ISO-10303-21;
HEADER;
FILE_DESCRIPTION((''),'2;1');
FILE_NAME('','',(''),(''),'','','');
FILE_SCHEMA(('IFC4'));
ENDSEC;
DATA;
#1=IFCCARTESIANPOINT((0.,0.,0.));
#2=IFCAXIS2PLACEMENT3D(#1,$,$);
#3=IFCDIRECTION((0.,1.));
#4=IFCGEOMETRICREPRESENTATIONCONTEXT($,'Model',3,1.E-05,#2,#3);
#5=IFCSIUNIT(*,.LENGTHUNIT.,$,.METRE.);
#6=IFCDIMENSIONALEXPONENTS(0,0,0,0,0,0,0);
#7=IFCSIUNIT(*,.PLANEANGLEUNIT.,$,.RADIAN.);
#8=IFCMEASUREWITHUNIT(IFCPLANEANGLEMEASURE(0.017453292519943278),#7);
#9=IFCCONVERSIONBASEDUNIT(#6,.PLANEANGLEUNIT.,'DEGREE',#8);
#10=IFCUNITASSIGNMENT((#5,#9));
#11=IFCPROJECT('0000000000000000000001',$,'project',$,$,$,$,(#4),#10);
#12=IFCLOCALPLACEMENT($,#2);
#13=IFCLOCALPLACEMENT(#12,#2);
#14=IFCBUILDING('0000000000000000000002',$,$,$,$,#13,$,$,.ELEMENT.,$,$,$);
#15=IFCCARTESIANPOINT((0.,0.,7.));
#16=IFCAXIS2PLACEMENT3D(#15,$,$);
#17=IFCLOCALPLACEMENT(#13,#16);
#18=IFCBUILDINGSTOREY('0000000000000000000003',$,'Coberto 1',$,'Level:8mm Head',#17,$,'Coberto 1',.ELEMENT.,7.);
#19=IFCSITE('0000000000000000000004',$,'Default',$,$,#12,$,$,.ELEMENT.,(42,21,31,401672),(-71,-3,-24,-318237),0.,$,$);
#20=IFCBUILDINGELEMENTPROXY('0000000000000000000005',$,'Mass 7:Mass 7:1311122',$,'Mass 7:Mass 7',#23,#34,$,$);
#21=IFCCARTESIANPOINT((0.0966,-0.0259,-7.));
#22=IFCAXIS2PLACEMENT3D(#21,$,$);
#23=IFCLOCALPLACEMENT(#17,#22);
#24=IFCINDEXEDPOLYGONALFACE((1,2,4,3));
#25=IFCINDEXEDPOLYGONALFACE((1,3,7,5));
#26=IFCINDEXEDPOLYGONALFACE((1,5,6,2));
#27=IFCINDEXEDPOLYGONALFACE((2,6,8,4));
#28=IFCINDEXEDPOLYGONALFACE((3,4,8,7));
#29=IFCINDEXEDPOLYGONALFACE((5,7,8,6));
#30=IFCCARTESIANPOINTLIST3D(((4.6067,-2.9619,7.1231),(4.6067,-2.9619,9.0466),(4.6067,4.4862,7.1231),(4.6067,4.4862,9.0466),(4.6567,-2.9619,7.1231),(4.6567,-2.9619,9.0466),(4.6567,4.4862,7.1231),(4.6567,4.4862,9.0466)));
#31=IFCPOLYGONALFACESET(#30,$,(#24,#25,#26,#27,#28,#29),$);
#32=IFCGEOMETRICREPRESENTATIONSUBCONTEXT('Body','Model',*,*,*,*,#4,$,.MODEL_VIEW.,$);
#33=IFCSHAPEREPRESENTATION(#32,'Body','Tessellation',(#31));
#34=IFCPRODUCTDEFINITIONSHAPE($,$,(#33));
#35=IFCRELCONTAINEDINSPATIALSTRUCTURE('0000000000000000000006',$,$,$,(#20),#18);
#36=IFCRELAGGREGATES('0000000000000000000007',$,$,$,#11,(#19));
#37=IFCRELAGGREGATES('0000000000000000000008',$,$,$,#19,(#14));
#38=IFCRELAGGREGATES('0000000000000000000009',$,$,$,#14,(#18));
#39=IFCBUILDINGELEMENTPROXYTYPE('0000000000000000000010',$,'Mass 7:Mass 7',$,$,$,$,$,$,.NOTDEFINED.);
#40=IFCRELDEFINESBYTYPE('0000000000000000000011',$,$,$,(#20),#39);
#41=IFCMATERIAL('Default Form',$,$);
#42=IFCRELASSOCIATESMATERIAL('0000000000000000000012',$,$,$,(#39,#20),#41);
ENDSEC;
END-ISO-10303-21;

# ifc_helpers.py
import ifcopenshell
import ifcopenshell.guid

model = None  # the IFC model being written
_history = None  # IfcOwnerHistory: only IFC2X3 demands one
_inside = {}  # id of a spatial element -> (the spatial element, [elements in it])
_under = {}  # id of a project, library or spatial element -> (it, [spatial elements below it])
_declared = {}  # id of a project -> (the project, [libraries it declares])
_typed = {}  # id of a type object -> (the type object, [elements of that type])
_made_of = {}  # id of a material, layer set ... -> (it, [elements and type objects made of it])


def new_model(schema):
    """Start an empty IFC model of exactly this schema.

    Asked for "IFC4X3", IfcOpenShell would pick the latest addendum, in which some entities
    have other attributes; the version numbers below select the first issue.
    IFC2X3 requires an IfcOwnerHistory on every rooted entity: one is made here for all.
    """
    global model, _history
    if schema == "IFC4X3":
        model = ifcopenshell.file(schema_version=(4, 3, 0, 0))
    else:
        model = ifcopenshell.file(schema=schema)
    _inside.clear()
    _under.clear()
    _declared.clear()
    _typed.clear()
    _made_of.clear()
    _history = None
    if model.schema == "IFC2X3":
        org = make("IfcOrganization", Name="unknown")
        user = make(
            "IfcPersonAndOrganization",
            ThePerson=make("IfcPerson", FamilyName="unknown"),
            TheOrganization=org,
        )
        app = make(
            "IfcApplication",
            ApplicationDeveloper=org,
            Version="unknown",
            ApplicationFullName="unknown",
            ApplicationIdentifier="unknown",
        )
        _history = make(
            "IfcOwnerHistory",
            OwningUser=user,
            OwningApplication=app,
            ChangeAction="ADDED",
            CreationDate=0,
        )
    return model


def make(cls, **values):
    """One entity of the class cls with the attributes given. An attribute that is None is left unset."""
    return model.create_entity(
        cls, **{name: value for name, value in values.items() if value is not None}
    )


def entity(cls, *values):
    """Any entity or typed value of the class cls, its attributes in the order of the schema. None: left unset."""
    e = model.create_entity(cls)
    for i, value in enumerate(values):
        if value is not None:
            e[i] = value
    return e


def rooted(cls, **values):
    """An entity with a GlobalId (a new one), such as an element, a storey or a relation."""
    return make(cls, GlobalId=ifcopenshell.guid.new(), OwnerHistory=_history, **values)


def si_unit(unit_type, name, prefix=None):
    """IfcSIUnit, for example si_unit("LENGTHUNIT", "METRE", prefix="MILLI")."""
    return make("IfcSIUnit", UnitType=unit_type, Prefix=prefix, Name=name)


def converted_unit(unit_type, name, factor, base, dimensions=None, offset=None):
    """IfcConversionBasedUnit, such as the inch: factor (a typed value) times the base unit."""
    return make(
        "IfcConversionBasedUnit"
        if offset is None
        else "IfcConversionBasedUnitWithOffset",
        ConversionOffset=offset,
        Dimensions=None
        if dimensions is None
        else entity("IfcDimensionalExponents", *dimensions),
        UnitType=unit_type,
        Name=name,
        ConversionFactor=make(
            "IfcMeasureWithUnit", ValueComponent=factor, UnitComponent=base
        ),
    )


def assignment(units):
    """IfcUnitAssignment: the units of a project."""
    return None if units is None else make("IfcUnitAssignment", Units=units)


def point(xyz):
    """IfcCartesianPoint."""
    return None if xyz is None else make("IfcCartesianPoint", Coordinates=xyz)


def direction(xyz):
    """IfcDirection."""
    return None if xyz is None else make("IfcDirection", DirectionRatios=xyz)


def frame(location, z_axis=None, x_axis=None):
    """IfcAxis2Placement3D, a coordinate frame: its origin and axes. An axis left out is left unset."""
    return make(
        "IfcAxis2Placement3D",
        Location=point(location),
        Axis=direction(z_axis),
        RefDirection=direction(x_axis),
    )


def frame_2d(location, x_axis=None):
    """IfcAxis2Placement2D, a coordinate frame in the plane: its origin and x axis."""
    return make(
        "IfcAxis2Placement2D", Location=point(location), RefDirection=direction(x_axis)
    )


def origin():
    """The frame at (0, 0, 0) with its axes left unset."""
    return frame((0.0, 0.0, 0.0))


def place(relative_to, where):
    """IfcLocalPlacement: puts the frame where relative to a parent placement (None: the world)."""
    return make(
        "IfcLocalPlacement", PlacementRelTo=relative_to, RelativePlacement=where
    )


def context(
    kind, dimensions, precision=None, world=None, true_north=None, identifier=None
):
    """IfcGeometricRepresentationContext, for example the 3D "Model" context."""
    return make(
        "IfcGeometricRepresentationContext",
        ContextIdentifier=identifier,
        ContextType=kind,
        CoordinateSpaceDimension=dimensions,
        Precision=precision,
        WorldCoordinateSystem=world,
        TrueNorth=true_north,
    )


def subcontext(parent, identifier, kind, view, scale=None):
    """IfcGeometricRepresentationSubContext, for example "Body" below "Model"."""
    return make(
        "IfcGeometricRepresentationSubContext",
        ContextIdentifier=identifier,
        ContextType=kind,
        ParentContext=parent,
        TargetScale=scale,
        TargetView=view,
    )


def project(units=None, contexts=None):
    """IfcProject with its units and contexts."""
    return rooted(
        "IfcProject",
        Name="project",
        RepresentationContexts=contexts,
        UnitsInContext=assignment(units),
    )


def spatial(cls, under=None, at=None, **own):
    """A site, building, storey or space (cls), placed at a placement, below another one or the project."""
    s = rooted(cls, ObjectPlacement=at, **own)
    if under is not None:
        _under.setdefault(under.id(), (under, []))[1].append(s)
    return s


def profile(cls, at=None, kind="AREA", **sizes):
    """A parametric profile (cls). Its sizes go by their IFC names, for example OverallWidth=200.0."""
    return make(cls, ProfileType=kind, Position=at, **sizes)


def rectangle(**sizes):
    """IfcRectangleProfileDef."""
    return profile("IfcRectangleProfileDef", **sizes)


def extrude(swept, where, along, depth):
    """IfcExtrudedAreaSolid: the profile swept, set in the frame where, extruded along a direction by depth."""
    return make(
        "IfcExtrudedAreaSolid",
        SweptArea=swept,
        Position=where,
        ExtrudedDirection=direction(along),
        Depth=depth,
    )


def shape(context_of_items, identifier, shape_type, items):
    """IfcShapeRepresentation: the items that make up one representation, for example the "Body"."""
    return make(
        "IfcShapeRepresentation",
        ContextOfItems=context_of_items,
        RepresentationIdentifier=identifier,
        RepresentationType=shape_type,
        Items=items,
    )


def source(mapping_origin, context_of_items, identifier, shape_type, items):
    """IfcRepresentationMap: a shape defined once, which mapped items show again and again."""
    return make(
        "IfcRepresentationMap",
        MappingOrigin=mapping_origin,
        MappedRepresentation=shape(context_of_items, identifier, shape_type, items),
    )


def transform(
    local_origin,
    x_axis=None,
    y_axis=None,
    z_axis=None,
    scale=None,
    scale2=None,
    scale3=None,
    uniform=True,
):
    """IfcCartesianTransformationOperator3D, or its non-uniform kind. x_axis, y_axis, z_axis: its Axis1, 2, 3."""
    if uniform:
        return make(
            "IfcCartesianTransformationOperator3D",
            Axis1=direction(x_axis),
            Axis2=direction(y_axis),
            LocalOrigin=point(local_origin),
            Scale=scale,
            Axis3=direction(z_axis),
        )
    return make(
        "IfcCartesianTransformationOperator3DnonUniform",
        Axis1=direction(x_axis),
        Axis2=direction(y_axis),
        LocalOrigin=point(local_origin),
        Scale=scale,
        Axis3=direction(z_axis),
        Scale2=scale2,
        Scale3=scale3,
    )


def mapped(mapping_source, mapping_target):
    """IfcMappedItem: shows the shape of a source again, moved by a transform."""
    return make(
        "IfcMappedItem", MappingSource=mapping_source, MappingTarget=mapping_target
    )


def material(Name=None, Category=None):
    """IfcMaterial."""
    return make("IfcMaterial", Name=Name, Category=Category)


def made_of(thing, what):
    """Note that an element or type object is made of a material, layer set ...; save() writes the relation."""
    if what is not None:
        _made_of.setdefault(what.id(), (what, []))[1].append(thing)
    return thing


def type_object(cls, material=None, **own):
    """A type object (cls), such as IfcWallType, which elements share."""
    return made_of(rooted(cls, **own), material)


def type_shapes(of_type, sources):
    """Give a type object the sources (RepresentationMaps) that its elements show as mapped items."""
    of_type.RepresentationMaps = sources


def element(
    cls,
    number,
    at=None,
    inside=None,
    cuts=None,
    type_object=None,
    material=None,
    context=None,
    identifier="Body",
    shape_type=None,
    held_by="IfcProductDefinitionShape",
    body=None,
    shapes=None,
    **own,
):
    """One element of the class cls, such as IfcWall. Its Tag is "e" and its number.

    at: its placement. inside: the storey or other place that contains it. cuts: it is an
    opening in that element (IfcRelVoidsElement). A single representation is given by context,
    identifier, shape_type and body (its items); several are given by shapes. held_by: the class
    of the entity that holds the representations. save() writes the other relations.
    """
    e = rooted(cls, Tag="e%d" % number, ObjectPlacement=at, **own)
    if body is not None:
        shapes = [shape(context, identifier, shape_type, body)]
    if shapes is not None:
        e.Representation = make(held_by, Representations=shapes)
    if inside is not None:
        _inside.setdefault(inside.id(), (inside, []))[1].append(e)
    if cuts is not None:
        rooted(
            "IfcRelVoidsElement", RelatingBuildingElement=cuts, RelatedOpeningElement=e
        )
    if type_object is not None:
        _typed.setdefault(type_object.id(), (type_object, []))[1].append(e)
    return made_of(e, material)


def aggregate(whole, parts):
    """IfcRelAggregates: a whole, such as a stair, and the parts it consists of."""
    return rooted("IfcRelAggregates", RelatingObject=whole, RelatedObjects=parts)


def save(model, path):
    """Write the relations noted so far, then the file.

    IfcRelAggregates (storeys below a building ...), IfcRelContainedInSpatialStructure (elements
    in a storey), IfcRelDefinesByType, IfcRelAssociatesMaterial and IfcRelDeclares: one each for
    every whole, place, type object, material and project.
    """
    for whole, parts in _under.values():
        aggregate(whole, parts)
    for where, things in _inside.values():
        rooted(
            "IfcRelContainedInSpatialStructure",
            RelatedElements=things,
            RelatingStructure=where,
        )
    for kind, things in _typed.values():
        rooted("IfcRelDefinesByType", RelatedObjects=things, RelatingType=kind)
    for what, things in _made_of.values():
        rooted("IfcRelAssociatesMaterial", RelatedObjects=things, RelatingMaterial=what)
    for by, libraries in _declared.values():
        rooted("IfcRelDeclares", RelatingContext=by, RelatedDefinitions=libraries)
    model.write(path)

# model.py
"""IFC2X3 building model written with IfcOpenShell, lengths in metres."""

from ifc_helpers import new_model, entity, si_unit, converted_unit, direction, frame, frame_2d, origin, place, context, subcontext, project, spatial, rectangle, extrude, source, transform, mapped, material, type_object, type_shapes, element, save


model = new_model("IFC2X3")

# Units and contexts
model_context = context("Model", 3, precision=1e-05, world=origin(), true_north=direction((0.0, 1.0)))
body_context = subcontext(model_context, "Body", "Model", "MODEL_VIEW")
ifc_project = project(units=[si_unit("LENGTHUNIT", "METRE"), converted_unit("PLANEANGLEUNIT", "DEGREE", entity("IfcPlaneAngleMeasure", 0.017453292519943278), si_unit("PLANEANGLEUNIT", "RADIAN"), dimensions=[0, 0, 0, 0, 0, 0, 0])], contexts=[model_context])

# Site, building, storey
site_placement = place(None, origin())
site = spatial("IfcSite", under=ifc_project, at=site_placement, Name="Default", CompositionType="ELEMENT", RefLatitude=(42, 21, 31, 401672), RefLongitude=(-71, -3, -24, -318237), RefElevation=0.0)
building_placement = place(site_placement, origin())
building = spatial("IfcBuilding", under=site, at=building_placement, CompositionType="ELEMENT")
storey_placement = place(building_placement, frame((0.0, 0.0, 7.0)))
storey = spatial("IfcBuildingStorey", under=building, at=storey_placement, Name="Coberto 1", ObjectType="Level:8mm Head", LongName="Coberto 1", CompositionType="ELEMENT", Elevation=7.0)

# Building element proxy
ifc_material_1 = material(Name="Default Form")
building_element_proxy_type_1 = type_object("IfcBuildingElementProxyType", Name="Mass 7:Mass 7", PredefinedType="NOTDEFINED", material=ifc_material_1)
shared_shape_1 = source(origin(), body_context, "Body", "SweptSolid", [
    extrude(rectangle(XDim=1.9235, YDim=7.4482, at=frame_2d((0.0, 0.0), x_axis=(1.0, 0.0))), frame((4.6067, 0.7622, 8.0848), z_axis=(1.0, 0.0, 0.0), x_axis=(0.0, 0.0, 1.0)), (0.0, 0.0, 1.0), 0.05),
])
type_shapes(building_element_proxy_type_1, [shared_shape_1])
proxy_1_placement = place(storey_placement, frame((0.0966, -0.0259, -7.0)))
element("IfcBuildingElementProxy", 1, at=proxy_1_placement, inside=storey, type_object=building_element_proxy_type_1, material=ifc_material_1, Name="Mass 7:Mass 7:1311122", ObjectType="Mass 7:Mass 7", context=body_context, shape_type="MappedRepresentation", body=[
    mapped(shared_shape_1, transform((0.0, 0.0, 0.0), scale=1.0)),
])

save(model, "model.ifc")
